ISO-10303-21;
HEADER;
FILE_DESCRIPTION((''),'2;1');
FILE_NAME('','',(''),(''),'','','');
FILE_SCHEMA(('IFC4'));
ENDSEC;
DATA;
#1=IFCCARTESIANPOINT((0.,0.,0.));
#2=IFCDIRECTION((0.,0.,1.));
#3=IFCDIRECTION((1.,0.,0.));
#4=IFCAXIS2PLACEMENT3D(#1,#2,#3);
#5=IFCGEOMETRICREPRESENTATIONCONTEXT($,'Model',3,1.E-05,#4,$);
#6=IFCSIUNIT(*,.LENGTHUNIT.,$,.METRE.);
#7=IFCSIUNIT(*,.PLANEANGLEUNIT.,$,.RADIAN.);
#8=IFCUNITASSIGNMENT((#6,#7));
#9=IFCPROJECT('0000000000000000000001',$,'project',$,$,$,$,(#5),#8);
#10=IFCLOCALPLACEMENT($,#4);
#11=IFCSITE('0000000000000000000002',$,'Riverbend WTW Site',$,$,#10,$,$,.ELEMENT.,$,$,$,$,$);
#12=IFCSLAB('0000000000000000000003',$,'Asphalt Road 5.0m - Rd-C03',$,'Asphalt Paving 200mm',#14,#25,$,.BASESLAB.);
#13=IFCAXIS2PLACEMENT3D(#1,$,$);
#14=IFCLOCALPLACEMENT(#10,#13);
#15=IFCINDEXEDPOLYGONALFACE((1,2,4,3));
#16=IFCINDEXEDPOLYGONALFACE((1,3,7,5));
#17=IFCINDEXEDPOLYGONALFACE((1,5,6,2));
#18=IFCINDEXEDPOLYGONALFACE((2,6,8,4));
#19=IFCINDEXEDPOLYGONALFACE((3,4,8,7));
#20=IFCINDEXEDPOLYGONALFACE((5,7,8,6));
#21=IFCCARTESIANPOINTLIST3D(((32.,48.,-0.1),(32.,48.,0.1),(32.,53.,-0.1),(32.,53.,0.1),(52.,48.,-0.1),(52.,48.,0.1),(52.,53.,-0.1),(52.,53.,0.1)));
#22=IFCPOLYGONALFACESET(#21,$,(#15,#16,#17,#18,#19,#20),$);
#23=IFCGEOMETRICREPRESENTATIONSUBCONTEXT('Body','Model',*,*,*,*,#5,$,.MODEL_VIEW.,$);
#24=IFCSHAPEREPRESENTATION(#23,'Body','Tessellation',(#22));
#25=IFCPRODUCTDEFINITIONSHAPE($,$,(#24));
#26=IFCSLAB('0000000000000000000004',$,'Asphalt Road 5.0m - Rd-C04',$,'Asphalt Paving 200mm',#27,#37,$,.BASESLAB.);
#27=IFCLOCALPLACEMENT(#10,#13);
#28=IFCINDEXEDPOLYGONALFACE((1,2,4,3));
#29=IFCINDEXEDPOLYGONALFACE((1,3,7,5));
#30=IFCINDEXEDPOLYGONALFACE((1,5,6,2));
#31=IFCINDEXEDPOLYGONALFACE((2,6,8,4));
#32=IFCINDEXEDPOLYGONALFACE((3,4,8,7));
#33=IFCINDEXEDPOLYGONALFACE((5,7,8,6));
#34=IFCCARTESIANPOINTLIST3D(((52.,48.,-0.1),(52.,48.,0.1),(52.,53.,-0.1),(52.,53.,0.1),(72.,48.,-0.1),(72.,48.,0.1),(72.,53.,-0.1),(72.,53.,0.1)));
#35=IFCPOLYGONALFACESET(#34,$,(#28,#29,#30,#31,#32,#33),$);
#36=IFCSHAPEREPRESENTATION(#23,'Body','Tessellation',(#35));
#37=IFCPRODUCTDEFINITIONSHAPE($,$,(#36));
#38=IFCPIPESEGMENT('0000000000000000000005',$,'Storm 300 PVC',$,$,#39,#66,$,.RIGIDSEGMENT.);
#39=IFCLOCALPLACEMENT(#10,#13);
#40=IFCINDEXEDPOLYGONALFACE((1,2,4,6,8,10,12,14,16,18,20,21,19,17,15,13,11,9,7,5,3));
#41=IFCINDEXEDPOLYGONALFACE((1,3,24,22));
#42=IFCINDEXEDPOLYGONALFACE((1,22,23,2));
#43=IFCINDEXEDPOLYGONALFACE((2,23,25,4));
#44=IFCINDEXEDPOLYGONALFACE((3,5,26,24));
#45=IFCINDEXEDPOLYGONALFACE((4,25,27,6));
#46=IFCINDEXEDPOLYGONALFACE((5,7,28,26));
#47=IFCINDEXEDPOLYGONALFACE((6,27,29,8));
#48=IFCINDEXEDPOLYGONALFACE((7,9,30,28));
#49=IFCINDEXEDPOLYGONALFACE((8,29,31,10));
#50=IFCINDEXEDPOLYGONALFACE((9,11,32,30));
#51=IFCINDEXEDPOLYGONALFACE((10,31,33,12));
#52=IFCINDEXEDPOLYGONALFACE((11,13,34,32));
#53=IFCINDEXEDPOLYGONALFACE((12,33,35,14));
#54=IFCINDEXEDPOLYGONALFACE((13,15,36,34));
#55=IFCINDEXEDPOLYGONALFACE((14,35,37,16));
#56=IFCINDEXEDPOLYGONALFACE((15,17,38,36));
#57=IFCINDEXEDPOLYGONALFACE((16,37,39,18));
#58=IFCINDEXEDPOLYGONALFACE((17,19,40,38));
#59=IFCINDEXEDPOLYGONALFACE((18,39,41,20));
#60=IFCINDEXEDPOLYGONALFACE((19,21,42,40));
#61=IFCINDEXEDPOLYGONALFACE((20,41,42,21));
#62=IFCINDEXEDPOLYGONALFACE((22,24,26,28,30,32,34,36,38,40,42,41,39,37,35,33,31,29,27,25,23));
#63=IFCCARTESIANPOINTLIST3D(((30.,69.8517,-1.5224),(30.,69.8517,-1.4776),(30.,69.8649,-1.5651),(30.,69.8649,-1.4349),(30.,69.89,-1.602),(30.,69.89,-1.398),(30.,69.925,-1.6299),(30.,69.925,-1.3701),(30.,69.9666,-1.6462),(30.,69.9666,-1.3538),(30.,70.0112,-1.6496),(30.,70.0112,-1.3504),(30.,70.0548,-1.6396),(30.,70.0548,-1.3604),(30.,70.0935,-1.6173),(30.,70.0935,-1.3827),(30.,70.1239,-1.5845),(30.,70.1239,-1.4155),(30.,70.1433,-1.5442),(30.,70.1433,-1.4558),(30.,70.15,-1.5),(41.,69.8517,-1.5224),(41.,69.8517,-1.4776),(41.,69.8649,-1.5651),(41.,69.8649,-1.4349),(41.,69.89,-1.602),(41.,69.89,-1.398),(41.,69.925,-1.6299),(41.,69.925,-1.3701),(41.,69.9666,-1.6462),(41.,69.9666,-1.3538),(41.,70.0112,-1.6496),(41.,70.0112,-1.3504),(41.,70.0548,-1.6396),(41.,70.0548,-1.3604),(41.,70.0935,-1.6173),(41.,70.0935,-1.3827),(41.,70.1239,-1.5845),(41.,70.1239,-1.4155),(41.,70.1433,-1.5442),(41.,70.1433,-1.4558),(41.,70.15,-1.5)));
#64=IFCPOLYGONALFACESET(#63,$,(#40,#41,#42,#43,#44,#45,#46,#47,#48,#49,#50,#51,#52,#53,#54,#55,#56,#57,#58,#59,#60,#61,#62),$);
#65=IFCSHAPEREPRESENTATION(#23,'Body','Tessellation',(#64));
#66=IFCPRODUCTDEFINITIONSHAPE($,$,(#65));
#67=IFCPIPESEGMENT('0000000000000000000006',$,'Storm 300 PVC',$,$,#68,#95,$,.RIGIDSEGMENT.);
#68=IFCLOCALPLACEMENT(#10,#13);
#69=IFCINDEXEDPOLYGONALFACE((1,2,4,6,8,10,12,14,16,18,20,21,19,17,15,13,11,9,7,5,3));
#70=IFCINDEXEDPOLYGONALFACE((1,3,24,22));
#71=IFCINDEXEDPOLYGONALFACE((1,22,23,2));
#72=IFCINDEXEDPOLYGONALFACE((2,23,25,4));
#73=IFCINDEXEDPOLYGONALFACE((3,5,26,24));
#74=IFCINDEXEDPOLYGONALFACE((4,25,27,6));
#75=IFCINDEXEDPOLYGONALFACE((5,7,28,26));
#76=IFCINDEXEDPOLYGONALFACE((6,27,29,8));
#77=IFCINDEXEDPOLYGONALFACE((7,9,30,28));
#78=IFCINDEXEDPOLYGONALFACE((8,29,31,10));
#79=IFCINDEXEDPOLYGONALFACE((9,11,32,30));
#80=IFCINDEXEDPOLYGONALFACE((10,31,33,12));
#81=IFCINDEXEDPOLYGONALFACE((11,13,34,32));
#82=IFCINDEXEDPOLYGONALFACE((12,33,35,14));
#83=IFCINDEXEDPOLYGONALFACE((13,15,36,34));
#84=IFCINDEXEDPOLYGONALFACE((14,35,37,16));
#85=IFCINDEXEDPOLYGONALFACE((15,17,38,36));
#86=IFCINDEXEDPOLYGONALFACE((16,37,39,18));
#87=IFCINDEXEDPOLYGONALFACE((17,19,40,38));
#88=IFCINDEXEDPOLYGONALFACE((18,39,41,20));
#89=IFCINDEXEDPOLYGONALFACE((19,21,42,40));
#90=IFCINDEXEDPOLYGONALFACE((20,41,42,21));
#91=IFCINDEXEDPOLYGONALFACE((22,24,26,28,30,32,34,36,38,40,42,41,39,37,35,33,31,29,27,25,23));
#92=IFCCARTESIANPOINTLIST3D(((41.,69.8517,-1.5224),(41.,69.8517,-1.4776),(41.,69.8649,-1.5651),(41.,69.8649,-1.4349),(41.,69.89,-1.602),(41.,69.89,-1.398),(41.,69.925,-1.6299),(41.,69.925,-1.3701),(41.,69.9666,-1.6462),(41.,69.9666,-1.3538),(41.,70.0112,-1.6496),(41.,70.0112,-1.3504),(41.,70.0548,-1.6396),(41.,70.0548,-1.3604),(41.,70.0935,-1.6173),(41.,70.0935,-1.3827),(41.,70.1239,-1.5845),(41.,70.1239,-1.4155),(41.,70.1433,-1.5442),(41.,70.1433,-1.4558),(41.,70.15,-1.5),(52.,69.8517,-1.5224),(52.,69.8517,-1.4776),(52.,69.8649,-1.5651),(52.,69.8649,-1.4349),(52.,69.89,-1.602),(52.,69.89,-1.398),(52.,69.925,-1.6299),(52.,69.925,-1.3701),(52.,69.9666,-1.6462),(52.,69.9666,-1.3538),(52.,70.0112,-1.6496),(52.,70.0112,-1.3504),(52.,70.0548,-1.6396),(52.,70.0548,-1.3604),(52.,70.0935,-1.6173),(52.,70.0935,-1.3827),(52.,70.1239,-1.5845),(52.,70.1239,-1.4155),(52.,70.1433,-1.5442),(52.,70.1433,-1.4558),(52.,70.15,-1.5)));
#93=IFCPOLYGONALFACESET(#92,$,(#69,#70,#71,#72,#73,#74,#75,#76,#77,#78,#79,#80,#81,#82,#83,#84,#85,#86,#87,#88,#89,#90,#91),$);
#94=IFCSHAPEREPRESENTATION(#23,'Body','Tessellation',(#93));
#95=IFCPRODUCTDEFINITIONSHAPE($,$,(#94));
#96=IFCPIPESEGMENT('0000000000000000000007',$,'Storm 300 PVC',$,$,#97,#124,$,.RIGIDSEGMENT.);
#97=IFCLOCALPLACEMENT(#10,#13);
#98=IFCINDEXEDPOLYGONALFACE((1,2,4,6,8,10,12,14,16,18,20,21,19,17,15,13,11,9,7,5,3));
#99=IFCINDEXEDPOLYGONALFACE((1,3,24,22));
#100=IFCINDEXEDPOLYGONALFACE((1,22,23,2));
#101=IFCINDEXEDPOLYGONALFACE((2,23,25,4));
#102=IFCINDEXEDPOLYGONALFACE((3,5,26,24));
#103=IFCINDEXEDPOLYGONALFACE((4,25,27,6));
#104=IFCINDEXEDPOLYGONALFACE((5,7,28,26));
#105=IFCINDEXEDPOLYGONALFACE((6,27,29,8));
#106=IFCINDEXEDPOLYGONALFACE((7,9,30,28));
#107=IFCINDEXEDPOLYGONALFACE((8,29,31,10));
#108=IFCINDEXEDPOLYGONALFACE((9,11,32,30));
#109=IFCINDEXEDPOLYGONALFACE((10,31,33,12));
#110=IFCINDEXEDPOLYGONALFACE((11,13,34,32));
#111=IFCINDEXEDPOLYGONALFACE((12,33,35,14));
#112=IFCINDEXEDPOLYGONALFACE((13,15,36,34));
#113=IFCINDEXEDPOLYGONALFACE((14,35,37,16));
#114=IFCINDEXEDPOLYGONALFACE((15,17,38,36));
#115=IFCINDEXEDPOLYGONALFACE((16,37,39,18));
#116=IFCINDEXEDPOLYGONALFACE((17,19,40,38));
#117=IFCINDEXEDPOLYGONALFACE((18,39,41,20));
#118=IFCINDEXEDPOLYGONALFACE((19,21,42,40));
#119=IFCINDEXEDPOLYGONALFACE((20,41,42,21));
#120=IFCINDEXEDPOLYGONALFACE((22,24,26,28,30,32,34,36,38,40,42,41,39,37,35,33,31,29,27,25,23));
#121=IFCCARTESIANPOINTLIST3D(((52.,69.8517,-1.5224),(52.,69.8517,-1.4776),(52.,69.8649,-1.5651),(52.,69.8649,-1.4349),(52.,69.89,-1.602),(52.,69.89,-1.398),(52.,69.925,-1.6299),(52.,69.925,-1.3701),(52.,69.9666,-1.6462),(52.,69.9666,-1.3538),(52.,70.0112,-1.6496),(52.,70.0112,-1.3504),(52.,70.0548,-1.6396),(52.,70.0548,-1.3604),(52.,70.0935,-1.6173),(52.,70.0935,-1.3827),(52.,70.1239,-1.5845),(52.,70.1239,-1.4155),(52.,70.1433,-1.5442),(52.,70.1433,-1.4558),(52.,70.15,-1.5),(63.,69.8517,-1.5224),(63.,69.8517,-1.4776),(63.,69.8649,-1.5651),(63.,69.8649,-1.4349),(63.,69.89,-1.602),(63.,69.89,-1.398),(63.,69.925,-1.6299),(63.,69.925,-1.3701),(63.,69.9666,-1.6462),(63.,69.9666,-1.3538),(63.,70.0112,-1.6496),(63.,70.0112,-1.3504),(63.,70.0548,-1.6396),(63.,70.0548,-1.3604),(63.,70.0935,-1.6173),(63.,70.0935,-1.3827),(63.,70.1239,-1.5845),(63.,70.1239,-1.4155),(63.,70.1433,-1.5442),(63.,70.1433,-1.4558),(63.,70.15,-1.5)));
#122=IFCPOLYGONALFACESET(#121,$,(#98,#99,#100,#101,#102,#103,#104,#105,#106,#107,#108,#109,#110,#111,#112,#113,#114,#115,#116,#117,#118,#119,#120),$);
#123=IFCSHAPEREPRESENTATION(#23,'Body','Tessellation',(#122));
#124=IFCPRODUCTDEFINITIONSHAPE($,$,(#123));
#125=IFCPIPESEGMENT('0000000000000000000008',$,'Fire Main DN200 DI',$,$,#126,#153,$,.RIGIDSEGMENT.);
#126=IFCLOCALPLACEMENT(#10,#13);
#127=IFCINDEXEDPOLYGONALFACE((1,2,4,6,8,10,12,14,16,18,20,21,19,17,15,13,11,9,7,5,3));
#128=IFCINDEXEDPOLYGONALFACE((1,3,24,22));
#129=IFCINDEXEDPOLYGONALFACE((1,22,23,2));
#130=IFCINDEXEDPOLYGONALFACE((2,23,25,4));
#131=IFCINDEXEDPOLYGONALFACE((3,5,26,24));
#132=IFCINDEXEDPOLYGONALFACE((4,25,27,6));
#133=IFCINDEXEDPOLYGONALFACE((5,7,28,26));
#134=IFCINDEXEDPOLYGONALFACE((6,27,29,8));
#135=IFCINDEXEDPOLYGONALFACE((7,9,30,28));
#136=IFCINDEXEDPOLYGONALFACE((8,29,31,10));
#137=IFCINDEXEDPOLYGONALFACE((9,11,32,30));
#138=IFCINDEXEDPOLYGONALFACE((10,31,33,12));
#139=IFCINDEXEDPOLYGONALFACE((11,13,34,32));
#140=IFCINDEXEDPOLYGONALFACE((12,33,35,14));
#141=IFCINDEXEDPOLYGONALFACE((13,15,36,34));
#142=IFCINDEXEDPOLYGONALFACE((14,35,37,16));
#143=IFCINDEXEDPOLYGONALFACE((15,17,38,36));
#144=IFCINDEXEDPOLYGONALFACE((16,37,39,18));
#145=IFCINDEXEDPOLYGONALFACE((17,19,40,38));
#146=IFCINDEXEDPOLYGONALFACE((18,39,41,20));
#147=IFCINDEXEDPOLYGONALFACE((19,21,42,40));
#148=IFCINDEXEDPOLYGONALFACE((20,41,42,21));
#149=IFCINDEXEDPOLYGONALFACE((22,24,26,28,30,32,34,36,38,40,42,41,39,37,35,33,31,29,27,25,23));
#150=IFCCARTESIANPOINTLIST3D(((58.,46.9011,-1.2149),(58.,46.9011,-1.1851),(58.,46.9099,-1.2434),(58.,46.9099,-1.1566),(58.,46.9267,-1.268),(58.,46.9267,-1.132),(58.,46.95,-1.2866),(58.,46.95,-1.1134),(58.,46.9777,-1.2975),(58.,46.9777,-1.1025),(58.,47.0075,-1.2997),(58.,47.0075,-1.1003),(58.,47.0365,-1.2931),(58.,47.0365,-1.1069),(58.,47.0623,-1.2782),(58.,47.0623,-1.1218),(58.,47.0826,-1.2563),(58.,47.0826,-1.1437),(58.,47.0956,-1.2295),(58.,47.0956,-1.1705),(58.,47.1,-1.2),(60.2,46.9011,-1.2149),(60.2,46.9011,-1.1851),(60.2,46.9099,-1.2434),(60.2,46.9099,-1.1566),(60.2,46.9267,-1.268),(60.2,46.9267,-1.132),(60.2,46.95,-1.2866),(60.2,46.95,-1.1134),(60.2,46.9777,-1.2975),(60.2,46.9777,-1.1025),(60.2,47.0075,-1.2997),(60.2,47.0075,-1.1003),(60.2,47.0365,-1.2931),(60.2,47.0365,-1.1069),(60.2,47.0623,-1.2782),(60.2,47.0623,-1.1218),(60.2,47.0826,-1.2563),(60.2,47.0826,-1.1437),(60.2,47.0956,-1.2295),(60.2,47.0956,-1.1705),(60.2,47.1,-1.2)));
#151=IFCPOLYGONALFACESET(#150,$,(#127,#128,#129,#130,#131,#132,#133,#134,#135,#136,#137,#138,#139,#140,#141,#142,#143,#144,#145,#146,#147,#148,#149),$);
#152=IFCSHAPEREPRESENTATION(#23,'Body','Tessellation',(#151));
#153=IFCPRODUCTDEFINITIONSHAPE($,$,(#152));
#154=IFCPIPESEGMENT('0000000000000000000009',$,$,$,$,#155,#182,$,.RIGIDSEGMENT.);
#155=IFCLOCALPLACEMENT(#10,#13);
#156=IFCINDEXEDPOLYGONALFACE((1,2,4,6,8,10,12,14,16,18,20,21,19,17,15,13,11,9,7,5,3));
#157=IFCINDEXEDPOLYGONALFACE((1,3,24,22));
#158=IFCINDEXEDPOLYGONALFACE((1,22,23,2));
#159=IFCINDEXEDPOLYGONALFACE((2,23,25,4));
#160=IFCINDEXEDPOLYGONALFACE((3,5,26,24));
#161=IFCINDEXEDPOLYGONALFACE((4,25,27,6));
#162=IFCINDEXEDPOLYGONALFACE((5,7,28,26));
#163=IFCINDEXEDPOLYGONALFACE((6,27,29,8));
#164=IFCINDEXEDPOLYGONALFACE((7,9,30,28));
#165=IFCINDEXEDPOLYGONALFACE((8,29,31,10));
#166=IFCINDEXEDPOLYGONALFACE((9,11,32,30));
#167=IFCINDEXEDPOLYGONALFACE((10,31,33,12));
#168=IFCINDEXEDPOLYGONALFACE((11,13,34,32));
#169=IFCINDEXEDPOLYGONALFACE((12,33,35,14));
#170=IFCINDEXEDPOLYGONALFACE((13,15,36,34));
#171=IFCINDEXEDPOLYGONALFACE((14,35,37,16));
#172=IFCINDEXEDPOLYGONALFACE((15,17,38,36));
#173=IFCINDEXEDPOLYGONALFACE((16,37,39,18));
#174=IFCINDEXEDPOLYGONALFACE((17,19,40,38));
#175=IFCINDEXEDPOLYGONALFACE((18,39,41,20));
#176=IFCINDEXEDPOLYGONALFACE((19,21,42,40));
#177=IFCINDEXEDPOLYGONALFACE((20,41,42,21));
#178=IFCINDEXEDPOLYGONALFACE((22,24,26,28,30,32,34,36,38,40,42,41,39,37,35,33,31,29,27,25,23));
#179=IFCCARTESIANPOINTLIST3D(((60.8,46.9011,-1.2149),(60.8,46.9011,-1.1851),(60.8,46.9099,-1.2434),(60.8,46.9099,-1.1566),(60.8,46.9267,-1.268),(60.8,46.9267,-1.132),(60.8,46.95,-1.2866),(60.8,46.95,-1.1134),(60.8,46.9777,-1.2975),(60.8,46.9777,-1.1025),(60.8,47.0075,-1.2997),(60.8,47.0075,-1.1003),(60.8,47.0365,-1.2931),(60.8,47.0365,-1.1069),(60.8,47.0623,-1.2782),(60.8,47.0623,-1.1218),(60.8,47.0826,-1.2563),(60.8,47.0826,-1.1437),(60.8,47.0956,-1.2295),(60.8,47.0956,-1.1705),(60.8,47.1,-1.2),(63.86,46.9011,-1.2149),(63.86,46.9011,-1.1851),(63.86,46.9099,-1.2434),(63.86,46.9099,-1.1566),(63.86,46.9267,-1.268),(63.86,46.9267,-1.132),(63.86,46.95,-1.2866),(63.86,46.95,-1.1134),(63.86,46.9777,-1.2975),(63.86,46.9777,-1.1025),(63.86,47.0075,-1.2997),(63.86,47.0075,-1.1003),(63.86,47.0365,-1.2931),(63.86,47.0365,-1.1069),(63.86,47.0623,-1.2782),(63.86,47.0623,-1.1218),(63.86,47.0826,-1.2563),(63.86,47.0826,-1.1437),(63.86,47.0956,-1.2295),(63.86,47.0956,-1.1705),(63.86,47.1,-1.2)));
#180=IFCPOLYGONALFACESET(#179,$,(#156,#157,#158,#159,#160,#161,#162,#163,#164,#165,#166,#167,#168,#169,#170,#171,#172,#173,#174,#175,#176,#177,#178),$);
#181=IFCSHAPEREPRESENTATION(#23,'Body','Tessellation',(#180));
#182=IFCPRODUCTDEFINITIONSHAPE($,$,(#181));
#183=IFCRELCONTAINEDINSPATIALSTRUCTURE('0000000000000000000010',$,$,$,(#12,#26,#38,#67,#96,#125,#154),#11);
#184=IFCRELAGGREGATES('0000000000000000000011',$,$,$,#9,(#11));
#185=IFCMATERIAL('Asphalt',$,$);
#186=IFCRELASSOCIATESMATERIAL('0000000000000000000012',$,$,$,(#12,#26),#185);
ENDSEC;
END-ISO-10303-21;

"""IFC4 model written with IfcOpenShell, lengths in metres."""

from ifc_helpers import new_model, si_unit, frame, origin_with_axes, origin_2d, place, context, subcontext, project, spatial, rectangle, circle, extrude, material, element, save


model = new_model("IFC4")

# Units and contexts
model_context = context("Model", 3, precision=1e-05, world=origin_with_axes())
body_context = subcontext(model_context, "Body", "Model", "MODEL_VIEW")
ifc_project = project(units=[si_unit("LENGTHUNIT", "METRE"), si_unit("PLANEANGLEUNIT", "RADIAN")], contexts=[model_context])

# Site
site_placement = place(None, origin_with_axes())
site = spatial("IfcSite", under=ifc_project, at=site_placement, Name="Riverbend WTW Site", CompositionType="ELEMENT")

# Slabs
ifc_material_1 = material(Name="Asphalt")
for number, where, z_axis, x_axis, name in (
    (1, (42.0, 50.5, 0.0), (0.0, 0.0, 1.0), (1.0, 0.0, 0.0), "Asphalt Road 5.0m - Rd-C03"),
    (2, (62.0, 50.5, 0.0), (0.0, 0.0, 1.0), (1.0, 0.0, 0.0), "Asphalt Road 5.0m - Rd-C04"),
):
    element("IfcSlab", number, at=place(None, frame(where, z_axis=z_axis, x_axis=x_axis)), inside=site, material=ifc_material_1, Name=name, ObjectType="Asphalt Paving 200mm", PredefinedType="BASESLAB", context=body_context, shape_type="SweptSolid", body=[
        extrude(rectangle(XDim=20.0, YDim=5.0, at=origin_2d()), frame((0.0, 0.0, -0.1), z_axis=(0.0, 0.0, 1.0), x_axis=(1.0, 0.0, 0.0)), (0.0, 0.0, 1.0), 0.2),
    ])

# Pipe segments
for number, where, z_axis, x_axis, name in (
    (3, (30.0, 70.0, -1.5), (0.0, 0.0, 1.0), (1.0, 0.0, 0.0), "Storm 300 PVC"),
    (4, (41.0, 70.0, -1.5), (0.0, 0.0, 1.0), (1.0, 0.0, 0.0), "Storm 300 PVC"),
    (5, (52.0, 70.0, -1.5), (0.0, 0.0, 1.0), (1.0, 0.0, 0.0), "Storm 300 PVC"),
):
    element("IfcPipeSegment", number, at=place(None, frame(where, z_axis=z_axis, x_axis=x_axis)), inside=site, Name=name, PredefinedType="RIGIDSEGMENT", context=body_context, shape_type="SweptSolid", body=[
        extrude(circle(Radius=0.15, at=origin_2d()), frame((0.0, 0.0, 0.0), z_axis=(1.0, 0.0, 0.0), x_axis=(0.0, 1.0, 0.0)), (0.0, 0.0, 1.0), 11.0),
    ])
pipe_segment_1_placement = place(None, frame((58.0, 47.0, -1.2), z_axis=(0.0, 0.0, 1.0), x_axis=(1.0, 0.0, 0.0)))
element("IfcPipeSegment", 6, at=pipe_segment_1_placement, inside=site, Name="Fire Main DN200 DI", PredefinedType="RIGIDSEGMENT", context=body_context, shape_type="SweptSolid", body=[
    extrude(circle(Radius=0.1, at=origin_2d()), frame((0.0, 0.0, 0.0), z_axis=(1.0, 0.0, 0.0), x_axis=(0.0, 1.0, 0.0)), (0.0, 0.0, 1.0), 2.2),
])
pipe_segment_2_placement = place(None, frame((60.8, 47.0, -1.2), z_axis=(0.0, 0.0, 1.0), x_axis=(1.0, 0.0, 0.0)))
element("IfcPipeSegment", 7, at=pipe_segment_2_placement, inside=site, PredefinedType="RIGIDSEGMENT", context=body_context, shape_type="SweptSolid", body=[
    extrude(circle(Radius=0.1, at=origin_2d()), frame((0.0, 0.0, 0.0), z_axis=(1.0, 0.0, 0.0), x_axis=(0.0, 1.0, 0.0)), (0.0, 0.0, 1.0), 3.06),
])

save(model, "model.ifc")
